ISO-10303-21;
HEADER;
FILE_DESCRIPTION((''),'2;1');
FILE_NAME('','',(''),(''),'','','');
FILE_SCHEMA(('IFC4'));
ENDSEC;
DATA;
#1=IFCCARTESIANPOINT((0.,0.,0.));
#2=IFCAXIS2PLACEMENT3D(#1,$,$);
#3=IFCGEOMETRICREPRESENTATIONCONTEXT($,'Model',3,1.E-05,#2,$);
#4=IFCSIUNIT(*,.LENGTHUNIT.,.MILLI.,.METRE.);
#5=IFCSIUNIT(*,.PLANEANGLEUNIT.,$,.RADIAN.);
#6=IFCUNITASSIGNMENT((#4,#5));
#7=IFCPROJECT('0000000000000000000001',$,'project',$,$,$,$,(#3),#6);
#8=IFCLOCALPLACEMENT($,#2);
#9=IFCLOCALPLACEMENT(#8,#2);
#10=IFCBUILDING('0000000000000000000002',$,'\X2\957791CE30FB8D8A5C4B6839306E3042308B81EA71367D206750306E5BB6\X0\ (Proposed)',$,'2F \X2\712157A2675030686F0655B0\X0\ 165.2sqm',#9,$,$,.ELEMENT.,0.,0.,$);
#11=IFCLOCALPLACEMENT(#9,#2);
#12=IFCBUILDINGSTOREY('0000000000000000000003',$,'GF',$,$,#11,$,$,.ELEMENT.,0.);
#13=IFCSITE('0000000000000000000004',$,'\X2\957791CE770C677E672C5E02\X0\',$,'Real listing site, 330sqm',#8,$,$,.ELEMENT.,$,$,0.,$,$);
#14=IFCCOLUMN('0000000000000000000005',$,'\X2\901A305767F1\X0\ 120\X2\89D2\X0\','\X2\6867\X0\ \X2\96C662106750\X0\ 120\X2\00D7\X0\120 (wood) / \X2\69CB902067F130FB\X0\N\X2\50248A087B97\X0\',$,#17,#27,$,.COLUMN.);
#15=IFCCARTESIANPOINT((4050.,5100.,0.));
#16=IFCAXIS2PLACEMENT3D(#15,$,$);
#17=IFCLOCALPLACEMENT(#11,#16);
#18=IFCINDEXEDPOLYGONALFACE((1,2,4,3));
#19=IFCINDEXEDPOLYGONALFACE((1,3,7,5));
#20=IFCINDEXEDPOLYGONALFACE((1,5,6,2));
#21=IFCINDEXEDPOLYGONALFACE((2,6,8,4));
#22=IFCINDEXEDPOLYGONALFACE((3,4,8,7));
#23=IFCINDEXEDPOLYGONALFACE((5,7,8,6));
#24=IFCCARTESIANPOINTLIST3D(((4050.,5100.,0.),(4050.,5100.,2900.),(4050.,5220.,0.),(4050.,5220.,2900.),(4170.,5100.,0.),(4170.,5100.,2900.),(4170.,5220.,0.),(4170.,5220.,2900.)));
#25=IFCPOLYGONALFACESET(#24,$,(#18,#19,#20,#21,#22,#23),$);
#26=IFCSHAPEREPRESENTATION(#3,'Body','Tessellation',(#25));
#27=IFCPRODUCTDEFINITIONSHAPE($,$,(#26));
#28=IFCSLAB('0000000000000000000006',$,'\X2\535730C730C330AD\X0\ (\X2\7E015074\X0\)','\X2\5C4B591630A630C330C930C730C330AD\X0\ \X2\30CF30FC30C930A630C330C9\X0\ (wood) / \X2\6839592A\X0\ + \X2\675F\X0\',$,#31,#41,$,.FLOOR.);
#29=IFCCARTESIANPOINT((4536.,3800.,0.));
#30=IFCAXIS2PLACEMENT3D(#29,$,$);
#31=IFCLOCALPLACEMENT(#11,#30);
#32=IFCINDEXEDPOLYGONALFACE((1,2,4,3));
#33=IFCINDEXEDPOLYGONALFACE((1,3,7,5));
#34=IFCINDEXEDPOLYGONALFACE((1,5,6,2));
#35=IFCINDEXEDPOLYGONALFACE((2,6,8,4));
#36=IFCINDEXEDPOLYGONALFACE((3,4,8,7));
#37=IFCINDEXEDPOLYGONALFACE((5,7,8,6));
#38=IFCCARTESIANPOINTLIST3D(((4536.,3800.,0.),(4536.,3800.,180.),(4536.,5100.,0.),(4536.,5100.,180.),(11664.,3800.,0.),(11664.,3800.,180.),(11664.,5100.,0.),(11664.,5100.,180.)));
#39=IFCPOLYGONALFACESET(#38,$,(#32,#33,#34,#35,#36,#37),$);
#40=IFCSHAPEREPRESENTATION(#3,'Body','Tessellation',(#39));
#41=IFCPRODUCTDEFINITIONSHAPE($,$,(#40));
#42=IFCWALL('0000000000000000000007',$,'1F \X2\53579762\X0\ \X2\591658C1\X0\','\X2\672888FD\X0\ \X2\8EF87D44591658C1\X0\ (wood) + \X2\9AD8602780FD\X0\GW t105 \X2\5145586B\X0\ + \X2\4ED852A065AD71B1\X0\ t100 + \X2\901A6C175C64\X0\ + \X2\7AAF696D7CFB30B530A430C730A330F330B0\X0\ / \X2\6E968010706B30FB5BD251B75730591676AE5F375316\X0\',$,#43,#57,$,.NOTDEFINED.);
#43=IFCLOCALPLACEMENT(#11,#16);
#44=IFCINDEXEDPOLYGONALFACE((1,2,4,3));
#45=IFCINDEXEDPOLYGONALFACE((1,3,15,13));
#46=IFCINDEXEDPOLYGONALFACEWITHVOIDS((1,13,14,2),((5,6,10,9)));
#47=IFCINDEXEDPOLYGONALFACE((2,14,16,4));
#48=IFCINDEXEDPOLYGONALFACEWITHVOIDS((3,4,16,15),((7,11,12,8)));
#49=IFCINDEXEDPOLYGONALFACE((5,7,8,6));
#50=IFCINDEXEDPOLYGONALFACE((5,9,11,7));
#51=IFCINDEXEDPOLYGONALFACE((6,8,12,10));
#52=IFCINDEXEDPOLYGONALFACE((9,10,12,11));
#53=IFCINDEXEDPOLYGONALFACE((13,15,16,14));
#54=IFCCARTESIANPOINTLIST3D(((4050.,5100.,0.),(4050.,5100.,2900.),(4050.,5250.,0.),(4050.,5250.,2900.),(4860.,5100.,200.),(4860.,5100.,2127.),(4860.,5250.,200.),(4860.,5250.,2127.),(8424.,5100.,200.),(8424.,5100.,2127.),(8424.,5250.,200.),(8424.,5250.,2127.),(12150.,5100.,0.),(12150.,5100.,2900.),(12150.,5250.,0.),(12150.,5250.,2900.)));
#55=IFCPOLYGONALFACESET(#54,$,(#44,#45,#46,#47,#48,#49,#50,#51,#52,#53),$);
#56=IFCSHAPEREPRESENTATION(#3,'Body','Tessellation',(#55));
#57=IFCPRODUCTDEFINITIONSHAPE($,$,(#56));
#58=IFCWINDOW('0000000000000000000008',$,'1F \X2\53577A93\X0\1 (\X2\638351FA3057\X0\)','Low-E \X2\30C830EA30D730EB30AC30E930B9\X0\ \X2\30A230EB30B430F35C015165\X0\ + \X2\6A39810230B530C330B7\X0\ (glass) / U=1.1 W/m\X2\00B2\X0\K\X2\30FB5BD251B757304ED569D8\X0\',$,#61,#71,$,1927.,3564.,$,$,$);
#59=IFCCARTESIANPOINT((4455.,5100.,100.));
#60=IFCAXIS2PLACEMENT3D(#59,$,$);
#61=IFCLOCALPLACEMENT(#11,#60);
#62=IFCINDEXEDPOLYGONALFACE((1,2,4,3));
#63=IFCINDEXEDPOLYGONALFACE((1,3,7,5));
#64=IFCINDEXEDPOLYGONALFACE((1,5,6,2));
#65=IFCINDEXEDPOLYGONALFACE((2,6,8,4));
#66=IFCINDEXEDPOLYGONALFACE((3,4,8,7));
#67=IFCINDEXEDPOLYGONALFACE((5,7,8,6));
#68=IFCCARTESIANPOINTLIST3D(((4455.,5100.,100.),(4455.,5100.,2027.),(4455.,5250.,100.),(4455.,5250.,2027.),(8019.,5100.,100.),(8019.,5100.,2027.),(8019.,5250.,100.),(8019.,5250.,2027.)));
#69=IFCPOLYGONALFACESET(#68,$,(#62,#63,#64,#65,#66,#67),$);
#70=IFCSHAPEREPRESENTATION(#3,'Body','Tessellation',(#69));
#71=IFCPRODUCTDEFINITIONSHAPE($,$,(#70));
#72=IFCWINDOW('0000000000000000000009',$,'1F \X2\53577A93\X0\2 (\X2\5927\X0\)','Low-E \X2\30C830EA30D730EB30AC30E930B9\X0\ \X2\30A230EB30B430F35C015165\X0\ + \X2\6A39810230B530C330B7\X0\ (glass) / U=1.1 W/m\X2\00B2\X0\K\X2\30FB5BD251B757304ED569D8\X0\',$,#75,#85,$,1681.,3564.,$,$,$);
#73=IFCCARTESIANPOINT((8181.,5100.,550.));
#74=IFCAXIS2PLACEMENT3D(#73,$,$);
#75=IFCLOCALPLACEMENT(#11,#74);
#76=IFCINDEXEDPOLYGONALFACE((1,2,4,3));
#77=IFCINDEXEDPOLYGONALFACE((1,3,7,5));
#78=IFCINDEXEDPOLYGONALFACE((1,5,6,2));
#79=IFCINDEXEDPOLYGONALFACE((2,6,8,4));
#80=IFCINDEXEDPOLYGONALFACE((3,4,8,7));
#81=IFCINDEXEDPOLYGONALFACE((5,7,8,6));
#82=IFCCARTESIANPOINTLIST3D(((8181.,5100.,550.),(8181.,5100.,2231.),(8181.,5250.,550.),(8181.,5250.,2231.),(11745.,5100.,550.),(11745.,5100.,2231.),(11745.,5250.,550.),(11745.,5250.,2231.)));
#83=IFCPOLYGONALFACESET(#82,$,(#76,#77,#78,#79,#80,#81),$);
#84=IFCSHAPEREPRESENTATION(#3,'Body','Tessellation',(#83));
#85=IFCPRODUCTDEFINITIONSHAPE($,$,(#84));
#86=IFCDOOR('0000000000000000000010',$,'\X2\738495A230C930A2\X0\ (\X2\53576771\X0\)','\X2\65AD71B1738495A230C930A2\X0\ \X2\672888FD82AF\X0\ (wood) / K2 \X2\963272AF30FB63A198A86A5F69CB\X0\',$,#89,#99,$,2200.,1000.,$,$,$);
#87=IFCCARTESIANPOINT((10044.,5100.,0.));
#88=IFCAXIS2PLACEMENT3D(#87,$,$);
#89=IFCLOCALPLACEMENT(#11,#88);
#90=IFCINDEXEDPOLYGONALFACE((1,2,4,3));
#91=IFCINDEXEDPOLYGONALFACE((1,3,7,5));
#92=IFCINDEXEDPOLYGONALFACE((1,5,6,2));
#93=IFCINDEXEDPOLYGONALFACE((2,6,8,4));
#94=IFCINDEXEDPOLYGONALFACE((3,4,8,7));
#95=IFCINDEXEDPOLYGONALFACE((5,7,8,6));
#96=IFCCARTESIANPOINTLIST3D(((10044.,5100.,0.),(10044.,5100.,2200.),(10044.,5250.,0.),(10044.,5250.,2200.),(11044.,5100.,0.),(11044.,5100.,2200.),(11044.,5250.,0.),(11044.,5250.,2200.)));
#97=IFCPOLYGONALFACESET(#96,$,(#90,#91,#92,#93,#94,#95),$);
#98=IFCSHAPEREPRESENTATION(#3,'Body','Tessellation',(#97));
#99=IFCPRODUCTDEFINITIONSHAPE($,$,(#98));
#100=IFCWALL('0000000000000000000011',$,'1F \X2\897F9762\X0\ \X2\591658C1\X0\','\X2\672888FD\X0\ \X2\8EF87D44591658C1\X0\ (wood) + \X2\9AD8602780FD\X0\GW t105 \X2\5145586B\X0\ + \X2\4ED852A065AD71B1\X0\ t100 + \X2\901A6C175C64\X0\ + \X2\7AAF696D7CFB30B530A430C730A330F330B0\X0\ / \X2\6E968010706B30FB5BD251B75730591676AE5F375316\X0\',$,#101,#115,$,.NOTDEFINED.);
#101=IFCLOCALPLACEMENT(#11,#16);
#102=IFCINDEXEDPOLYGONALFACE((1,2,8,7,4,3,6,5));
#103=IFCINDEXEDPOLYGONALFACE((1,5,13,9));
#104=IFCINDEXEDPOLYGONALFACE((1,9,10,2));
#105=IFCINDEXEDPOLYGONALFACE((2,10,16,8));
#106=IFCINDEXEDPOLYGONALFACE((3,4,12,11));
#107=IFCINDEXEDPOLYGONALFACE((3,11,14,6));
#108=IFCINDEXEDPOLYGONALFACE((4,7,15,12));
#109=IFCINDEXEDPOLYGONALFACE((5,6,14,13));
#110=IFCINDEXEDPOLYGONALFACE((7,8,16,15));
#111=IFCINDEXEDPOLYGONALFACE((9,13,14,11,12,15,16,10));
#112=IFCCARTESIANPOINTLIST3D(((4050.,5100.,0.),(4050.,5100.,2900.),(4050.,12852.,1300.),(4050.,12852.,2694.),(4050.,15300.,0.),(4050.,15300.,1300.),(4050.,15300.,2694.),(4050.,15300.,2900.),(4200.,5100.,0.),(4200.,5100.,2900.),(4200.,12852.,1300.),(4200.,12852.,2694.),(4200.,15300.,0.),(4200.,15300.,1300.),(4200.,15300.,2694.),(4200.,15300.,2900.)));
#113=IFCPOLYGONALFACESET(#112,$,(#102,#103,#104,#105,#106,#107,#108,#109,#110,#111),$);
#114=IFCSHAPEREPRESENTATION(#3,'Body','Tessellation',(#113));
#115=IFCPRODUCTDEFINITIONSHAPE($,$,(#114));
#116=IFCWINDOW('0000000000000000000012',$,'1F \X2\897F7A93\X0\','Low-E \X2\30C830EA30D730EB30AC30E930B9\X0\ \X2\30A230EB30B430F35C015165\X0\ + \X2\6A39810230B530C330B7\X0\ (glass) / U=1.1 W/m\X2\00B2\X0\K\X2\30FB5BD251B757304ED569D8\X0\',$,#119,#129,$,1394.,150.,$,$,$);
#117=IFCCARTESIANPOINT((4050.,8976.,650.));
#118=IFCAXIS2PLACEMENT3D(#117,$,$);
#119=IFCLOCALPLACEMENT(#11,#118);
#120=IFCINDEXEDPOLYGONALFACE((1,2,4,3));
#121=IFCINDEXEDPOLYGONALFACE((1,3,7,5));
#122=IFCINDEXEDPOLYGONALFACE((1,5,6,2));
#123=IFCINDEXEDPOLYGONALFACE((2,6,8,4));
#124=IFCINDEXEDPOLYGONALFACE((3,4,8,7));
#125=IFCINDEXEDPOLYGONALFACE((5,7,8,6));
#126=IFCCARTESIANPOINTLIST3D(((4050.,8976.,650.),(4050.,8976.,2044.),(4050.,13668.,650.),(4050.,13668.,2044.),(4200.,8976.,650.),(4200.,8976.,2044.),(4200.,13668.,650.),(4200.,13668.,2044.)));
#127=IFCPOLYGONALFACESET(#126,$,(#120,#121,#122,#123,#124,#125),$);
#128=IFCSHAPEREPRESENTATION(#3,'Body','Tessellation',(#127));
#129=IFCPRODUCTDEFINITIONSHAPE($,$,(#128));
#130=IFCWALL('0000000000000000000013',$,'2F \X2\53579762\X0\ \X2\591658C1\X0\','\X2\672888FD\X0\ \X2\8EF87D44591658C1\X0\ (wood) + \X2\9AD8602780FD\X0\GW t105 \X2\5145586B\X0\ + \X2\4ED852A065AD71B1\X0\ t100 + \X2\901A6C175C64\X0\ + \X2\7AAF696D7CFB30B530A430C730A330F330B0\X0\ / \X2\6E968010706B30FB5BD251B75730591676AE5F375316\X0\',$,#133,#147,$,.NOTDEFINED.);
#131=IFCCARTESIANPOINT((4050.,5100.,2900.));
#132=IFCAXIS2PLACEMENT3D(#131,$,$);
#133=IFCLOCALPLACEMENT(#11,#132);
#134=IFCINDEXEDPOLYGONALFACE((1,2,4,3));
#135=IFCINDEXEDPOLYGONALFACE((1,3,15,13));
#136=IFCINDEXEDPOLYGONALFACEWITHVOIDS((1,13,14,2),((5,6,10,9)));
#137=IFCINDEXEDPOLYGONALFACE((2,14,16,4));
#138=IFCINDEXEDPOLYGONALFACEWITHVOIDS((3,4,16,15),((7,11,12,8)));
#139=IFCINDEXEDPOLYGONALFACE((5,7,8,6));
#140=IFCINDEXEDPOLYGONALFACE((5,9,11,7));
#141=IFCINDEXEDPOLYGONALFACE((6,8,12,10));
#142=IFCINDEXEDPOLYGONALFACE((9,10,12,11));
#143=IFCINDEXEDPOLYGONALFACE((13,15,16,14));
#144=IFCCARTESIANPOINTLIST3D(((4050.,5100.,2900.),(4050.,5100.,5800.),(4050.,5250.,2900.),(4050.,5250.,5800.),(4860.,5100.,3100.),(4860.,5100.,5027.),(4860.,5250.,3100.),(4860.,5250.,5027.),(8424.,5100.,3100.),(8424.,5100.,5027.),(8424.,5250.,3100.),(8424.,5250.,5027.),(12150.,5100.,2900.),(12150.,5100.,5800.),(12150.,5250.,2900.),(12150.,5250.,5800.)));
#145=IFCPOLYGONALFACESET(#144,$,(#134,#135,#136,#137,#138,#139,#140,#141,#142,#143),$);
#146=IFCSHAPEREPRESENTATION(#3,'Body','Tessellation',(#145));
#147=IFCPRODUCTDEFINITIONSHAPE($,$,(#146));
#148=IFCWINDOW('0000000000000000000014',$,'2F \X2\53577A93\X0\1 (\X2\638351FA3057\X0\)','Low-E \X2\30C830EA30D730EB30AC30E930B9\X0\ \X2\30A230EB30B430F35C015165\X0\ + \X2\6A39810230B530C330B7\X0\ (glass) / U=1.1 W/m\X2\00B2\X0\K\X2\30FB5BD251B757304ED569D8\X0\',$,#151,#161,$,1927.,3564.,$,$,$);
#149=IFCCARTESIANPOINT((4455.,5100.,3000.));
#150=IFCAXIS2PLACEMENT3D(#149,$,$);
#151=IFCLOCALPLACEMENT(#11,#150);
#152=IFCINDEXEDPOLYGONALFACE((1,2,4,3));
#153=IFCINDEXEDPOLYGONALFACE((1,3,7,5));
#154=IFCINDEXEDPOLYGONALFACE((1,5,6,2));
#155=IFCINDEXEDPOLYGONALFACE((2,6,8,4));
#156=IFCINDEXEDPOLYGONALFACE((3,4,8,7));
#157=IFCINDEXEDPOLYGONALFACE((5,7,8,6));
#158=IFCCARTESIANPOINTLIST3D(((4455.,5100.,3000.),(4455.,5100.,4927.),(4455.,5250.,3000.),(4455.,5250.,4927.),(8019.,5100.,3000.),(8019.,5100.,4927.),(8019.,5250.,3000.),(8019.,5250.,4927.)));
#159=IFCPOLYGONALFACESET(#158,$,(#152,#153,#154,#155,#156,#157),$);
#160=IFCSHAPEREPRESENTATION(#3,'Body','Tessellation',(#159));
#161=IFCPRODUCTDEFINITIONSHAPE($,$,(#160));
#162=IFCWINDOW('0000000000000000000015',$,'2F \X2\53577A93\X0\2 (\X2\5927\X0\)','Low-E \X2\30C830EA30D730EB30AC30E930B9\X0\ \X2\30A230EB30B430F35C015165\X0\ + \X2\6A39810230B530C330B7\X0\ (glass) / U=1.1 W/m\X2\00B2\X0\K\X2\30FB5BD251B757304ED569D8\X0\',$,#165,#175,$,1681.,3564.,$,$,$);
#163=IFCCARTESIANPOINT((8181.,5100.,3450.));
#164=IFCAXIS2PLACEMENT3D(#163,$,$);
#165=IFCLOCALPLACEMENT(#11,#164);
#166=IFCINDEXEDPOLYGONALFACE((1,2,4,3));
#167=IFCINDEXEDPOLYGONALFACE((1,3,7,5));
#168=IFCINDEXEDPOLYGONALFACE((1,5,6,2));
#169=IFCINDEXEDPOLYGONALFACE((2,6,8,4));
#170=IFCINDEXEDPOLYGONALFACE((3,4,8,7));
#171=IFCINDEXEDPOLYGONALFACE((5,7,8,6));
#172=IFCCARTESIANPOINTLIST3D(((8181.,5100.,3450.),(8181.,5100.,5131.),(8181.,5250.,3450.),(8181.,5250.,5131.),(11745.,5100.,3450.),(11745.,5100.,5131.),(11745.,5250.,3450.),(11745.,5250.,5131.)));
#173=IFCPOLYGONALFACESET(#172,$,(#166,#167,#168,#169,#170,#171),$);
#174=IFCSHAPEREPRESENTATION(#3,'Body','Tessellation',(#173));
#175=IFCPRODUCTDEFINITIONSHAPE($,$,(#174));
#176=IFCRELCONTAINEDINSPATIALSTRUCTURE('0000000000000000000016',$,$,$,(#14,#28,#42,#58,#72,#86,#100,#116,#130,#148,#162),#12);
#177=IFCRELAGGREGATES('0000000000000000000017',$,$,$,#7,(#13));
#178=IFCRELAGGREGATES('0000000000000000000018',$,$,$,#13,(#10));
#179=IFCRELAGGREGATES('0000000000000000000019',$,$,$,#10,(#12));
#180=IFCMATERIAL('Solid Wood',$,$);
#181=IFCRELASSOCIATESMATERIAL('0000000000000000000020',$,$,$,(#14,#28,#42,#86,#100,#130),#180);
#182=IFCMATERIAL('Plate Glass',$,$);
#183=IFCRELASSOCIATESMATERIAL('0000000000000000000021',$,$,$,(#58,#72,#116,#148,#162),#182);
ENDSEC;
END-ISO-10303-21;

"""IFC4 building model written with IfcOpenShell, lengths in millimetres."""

from ifc_helpers import new_model, si_unit, frame, frame_2d, origin, place, context, project, spatial, rectangle, extrude, material, element, fill, save


model = new_model("IFC4")

# Units and contexts
model_context = context("Model", 3, precision=1e-05, world=origin())
ifc_project = project(units=[si_unit("LENGTHUNIT", "METRE", prefix="MILLI"), si_unit("PLANEANGLEUNIT", "RADIAN")], contexts=[model_context])

# Site, building, storey
site_placement = place(None, origin())
site = spatial("IfcSite", under=ifc_project, at=site_placement, Name="長野県松本市", ObjectType="Real listing site, 330sqm", CompositionType="ELEMENT", RefElevation=0.0)
building_placement = place(site_placement, origin())
building = spatial("IfcBuilding", under=site, at=building_placement, Name="長野・越屋根のある自然素材の家 (Proposed)", ObjectType="2F 無垢材と漆喰 165.2sqm", CompositionType="ELEMENT", ElevationOfRefHeight=0.0, ElevationOfTerrain=0.0)
storey_placement = place(building_placement, origin())
storey = spatial("IfcBuildingStorey", under=building, at=storey_placement, Name="GF", CompositionType="ELEMENT", Elevation=0.0)

# Column
ifc_material_1 = material(Name="Solid Wood")
column_placement = place(storey_placement, frame((4050.0, 5100.0, 0.0)))
element("IfcColumn", 1, at=column_placement, inside=storey, material=ifc_material_1, Name="通し柱 120角", Description="桧 集成材 120×120 (wood) / 構造柱・N値計算", PredefinedType="COLUMN", context=model_context, shape_type="SweptSolid", body=[
    extrude(rectangle(XDim=120.0, YDim=120.0, at=frame_2d((60.0, 60.0))), frame((4050.0, 5100.0, 0.0)), (0.0, 0.0, 1.0), 2900.0),
])

# Slab
slab_1_placement = place(storey_placement, frame((4536.0, 3800.0, 0.0)))
element("IfcSlab", 2, at=slab_1_placement, inside=storey, material=ifc_material_1, Name="南デッキ (縁側)", Description="屋外ウッドデッキ ハードウッド (wood) / 根太 + 束", PredefinedType="FLOOR", context=model_context, shape_type="SweptSolid", body=[
    extrude(rectangle(XDim=7128.0, YDim=1300.0, at=frame_2d((3564.0, 650.0))), frame((4536.0, 3800.0, 0.0)), (0.0, 0.0, 1.0), 180.0),
])

# Wall, openings, windows, door
wall_1_placement = place(storey_placement, frame((4050.0, 5100.0, 0.0)))
wall_1 = element("IfcWall", 3, at=wall_1_placement, inside=storey, material=ifc_material_1, Name="1F 南面 外壁", Description="木製 軸組外壁 (wood) + 高性能GW t105 充填 + 付加断熱 t100 + 通気層 + 窯業系サイディング / 準耐火・寒冷地外皮強化", PredefinedType="NOTDEFINED", context=model_context, shape_type="SweptSolid", body=[
    extrude(rectangle(XDim=8100.0, YDim=150.0, at=frame_2d((4050.0, 75.0))), frame((4050.0, 5100.0, 0.0)), (0.0, 0.0, 1.0), 2900.0),
])
opening_1_placement = place(storey_placement, frame((4455.0, 5100.0, 100.0)))
opening_1 = element("IfcOpeningElement", 4, at=opening_1_placement, cuts=wall_1, PredefinedType="NOTDEFINED", context=model_context, shape_type="SweptSolid", body=[
    extrude(rectangle(XDim=3564.0, YDim=150.0, at=frame_2d((1782.0, 75.0))), frame((4455.0, 5100.0, 100.0)), (0.0, 0.0, 1.0), 1927.0),
])
opening_2_placement = place(storey_placement, frame((8181.0, 5100.0, 550.0)))
opening_2 = element("IfcOpeningElement", 5, at=opening_2_placement, cuts=wall_1, PredefinedType="NOTDEFINED", context=model_context, shape_type="SweptSolid", body=[
    extrude(rectangle(XDim=3564.0, YDim=150.0, at=frame_2d((1782.0, 75.0))), frame((8181.0, 5100.0, 550.0)), (0.0, 0.0, 1.0), 1681.0),
])
opening_3_placement = place(storey_placement, frame((10044.0, 5100.0, 0.0)))
opening_3 = element("IfcOpeningElement", 6, at=opening_3_placement, cuts=wall_1, PredefinedType="NOTDEFINED", context=model_context, shape_type="SweptSolid", body=[
    extrude(rectangle(XDim=1000.0, YDim=150.0, at=frame_2d((500.0, 75.0))), frame((10044.0, 5100.0, 0.0)), (0.0, 0.0, 1.0), 2200.0),
])
ifc_material_2 = material(Name="Plate Glass")
window_1_placement = place(storey_placement, frame((4455.0, 5100.0, 100.0)))
window_1 = element("IfcWindow", 7, at=window_1_placement, inside=storey, material=ifc_material_2, Name="1F 南窓1 (掃出し)", Description="Low-E トリプルガラス アルゴン封入 + 樹脂サッシ (glass) / U=1.1 W/m²K・寒冷地仕様", OverallHeight=1927.0, OverallWidth=3564.0, context=model_context, shape_type="SweptSolid", body=[
    extrude(rectangle(XDim=3564.0, YDim=150.0, at=frame_2d((1782.0, 75.0))), frame((4455.0, 5100.0, 100.0)), (0.0, 0.0, 1.0), 1927.0),
])
fill(opening_1, window_1)
window_2_placement = place(storey_placement, frame((8181.0, 5100.0, 550.0)))
window_2 = element("IfcWindow", 8, at=window_2_placement, inside=storey, material=ifc_material_2, Name="1F 南窓2 (大)", Description="Low-E トリプルガラス アルゴン封入 + 樹脂サッシ (glass) / U=1.1 W/m²K・寒冷地仕様", OverallHeight=1681.0, OverallWidth=3564.0, context=model_context, shape_type="SweptSolid", body=[
    extrude(rectangle(XDim=3564.0, YDim=150.0, at=frame_2d((1782.0, 75.0))), frame((8181.0, 5100.0, 550.0)), (0.0, 0.0, 1.0), 1681.0),
])
fill(opening_2, window_2)
door_placement = place(storey_placement, frame((10044.0, 5100.0, 0.0)))
door = element("IfcDoor", 9, at=door_placement, inside=storey, material=ifc_material_1, Name="玄関ドア (南東)", Description="断熱玄関ドア 木製芯 (wood) / K2 防犯・採風機構", OverallHeight=2200.0, OverallWidth=1000.0, context=model_context, shape_type="SweptSolid", body=[
    extrude(rectangle(XDim=1000.0, YDim=150.0, at=frame_2d((500.0, 75.0))), frame((10044.0, 5100.0, 0.0)), (0.0, 0.0, 1.0), 2200.0),
])
fill(opening_3, door)

# Wall, opening, window
wall_2_placement = place(storey_placement, frame((4050.0, 5100.0, 0.0)))
wall_2 = element("IfcWall", 10, at=wall_2_placement, inside=storey, material=ifc_material_1, Name="1F 西面 外壁", Description="木製 軸組外壁 (wood) + 高性能GW t105 充填 + 付加断熱 t100 + 通気層 + 窯業系サイディング / 準耐火・寒冷地外皮強化", PredefinedType="NOTDEFINED", context=model_context, shape_type="SweptSolid", body=[
    extrude(rectangle(XDim=150.0, YDim=10200.0, at=frame_2d((75.0, 5100.0))), frame((4050.0, 5100.0, 0.0)), (0.0, 0.0, 1.0), 2900.0),
])
opening_4_placement = place(storey_placement, frame((4050.0, 8976.0, 650.0)))
opening_4 = element("IfcOpeningElement", 11, at=opening_4_placement, cuts=wall_2, PredefinedType="NOTDEFINED", context=model_context, shape_type="SweptSolid", body=[
    extrude(rectangle(XDim=150.0, YDim=4692.0, at=frame_2d((75.0, 2346.0))), frame((4050.0, 8976.0, 650.0)), (0.0, 0.0, 1.0), 1394.0),
])
window_3_placement = place(storey_placement, frame((4050.0, 8976.0, 650.0)))
window_3 = element("IfcWindow", 12, at=window_3_placement, inside=storey, material=ifc_material_2, Name="1F 西窓", Description="Low-E トリプルガラス アルゴン封入 + 樹脂サッシ (glass) / U=1.1 W/m²K・寒冷地仕様", OverallHeight=1394.0, OverallWidth=150.0, context=model_context, shape_type="SweptSolid", body=[
    extrude(rectangle(XDim=150.0, YDim=4692.0, at=frame_2d((75.0, 2346.0))), frame((4050.0, 8976.0, 650.0)), (0.0, 0.0, 1.0), 1394.0),
])
fill(opening_4, window_3)

# Wall, openings, windows
wall_3_placement = place(storey_placement, frame((4050.0, 5100.0, 2900.0)))
wall_3 = element("IfcWall", 13, at=wall_3_placement, inside=storey, material=ifc_material_1, Name="2F 南面 外壁", Description="木製 軸組外壁 (wood) + 高性能GW t105 充填 + 付加断熱 t100 + 通気層 + 窯業系サイディング / 準耐火・寒冷地外皮強化", PredefinedType="NOTDEFINED", context=model_context, shape_type="SweptSolid", body=[
    extrude(rectangle(XDim=8100.0, YDim=150.0, at=frame_2d((4050.0, 75.0))), frame((4050.0, 5100.0, 2900.0)), (0.0, 0.0, 1.0), 2900.0),
])
opening_5_placement = place(storey_placement, frame((4455.0, 5100.0, 3000.0)))
opening_5 = element("IfcOpeningElement", 14, at=opening_5_placement, cuts=wall_3, PredefinedType="NOTDEFINED", context=model_context, shape_type="SweptSolid", body=[
    extrude(rectangle(XDim=3564.0, YDim=150.0, at=frame_2d((1782.0, 75.0))), frame((4455.0, 5100.0, 3000.0)), (0.0, 0.0, 1.0), 1927.0),
])
opening_6_placement = place(storey_placement, frame((8181.0, 5100.0, 3450.0)))
opening_6 = element("IfcOpeningElement", 15, at=opening_6_placement, cuts=wall_3, PredefinedType="NOTDEFINED", context=model_context, shape_type="SweptSolid", body=[
    extrude(rectangle(XDim=3564.0, YDim=150.0, at=frame_2d((1782.0, 75.0))), frame((8181.0, 5100.0, 3450.0)), (0.0, 0.0, 1.0), 1681.0),
])
window_4_placement = place(storey_placement, frame((4455.0, 5100.0, 3000.0)))
window_4 = element("IfcWindow", 16, at=window_4_placement, inside=storey, material=ifc_material_2, Name="2F 南窓1 (掃出し)", Description="Low-E トリプルガラス アルゴン封入 + 樹脂サッシ (glass) / U=1.1 W/m²K・寒冷地仕様", OverallHeight=1927.0, OverallWidth=3564.0, context=model_context, shape_type="SweptSolid", body=[
    extrude(rectangle(XDim=3564.0, YDim=150.0, at=frame_2d((1782.0, 75.0))), frame((4455.0, 5100.0, 3000.0)), (0.0, 0.0, 1.0), 1927.0),
])
fill(opening_5, window_4)
window_5_placement = place(storey_placement, frame((8181.0, 5100.0, 3450.0)))
window_5 = element("IfcWindow", 17, at=window_5_placement, inside=storey, material=ifc_material_2, Name="2F 南窓2 (大)", Description="Low-E トリプルガラス アルゴン封入 + 樹脂サッシ (glass) / U=1.1 W/m²K・寒冷地仕様", OverallHeight=1681.0, OverallWidth=3564.0, context=model_context, shape_type="SweptSolid", body=[
    extrude(rectangle(XDim=3564.0, YDim=150.0, at=frame_2d((1782.0, 75.0))), frame((8181.0, 5100.0, 3450.0)), (0.0, 0.0, 1.0), 1681.0),
])
fill(opening_6, window_5)

save(model, "model.ifc")
